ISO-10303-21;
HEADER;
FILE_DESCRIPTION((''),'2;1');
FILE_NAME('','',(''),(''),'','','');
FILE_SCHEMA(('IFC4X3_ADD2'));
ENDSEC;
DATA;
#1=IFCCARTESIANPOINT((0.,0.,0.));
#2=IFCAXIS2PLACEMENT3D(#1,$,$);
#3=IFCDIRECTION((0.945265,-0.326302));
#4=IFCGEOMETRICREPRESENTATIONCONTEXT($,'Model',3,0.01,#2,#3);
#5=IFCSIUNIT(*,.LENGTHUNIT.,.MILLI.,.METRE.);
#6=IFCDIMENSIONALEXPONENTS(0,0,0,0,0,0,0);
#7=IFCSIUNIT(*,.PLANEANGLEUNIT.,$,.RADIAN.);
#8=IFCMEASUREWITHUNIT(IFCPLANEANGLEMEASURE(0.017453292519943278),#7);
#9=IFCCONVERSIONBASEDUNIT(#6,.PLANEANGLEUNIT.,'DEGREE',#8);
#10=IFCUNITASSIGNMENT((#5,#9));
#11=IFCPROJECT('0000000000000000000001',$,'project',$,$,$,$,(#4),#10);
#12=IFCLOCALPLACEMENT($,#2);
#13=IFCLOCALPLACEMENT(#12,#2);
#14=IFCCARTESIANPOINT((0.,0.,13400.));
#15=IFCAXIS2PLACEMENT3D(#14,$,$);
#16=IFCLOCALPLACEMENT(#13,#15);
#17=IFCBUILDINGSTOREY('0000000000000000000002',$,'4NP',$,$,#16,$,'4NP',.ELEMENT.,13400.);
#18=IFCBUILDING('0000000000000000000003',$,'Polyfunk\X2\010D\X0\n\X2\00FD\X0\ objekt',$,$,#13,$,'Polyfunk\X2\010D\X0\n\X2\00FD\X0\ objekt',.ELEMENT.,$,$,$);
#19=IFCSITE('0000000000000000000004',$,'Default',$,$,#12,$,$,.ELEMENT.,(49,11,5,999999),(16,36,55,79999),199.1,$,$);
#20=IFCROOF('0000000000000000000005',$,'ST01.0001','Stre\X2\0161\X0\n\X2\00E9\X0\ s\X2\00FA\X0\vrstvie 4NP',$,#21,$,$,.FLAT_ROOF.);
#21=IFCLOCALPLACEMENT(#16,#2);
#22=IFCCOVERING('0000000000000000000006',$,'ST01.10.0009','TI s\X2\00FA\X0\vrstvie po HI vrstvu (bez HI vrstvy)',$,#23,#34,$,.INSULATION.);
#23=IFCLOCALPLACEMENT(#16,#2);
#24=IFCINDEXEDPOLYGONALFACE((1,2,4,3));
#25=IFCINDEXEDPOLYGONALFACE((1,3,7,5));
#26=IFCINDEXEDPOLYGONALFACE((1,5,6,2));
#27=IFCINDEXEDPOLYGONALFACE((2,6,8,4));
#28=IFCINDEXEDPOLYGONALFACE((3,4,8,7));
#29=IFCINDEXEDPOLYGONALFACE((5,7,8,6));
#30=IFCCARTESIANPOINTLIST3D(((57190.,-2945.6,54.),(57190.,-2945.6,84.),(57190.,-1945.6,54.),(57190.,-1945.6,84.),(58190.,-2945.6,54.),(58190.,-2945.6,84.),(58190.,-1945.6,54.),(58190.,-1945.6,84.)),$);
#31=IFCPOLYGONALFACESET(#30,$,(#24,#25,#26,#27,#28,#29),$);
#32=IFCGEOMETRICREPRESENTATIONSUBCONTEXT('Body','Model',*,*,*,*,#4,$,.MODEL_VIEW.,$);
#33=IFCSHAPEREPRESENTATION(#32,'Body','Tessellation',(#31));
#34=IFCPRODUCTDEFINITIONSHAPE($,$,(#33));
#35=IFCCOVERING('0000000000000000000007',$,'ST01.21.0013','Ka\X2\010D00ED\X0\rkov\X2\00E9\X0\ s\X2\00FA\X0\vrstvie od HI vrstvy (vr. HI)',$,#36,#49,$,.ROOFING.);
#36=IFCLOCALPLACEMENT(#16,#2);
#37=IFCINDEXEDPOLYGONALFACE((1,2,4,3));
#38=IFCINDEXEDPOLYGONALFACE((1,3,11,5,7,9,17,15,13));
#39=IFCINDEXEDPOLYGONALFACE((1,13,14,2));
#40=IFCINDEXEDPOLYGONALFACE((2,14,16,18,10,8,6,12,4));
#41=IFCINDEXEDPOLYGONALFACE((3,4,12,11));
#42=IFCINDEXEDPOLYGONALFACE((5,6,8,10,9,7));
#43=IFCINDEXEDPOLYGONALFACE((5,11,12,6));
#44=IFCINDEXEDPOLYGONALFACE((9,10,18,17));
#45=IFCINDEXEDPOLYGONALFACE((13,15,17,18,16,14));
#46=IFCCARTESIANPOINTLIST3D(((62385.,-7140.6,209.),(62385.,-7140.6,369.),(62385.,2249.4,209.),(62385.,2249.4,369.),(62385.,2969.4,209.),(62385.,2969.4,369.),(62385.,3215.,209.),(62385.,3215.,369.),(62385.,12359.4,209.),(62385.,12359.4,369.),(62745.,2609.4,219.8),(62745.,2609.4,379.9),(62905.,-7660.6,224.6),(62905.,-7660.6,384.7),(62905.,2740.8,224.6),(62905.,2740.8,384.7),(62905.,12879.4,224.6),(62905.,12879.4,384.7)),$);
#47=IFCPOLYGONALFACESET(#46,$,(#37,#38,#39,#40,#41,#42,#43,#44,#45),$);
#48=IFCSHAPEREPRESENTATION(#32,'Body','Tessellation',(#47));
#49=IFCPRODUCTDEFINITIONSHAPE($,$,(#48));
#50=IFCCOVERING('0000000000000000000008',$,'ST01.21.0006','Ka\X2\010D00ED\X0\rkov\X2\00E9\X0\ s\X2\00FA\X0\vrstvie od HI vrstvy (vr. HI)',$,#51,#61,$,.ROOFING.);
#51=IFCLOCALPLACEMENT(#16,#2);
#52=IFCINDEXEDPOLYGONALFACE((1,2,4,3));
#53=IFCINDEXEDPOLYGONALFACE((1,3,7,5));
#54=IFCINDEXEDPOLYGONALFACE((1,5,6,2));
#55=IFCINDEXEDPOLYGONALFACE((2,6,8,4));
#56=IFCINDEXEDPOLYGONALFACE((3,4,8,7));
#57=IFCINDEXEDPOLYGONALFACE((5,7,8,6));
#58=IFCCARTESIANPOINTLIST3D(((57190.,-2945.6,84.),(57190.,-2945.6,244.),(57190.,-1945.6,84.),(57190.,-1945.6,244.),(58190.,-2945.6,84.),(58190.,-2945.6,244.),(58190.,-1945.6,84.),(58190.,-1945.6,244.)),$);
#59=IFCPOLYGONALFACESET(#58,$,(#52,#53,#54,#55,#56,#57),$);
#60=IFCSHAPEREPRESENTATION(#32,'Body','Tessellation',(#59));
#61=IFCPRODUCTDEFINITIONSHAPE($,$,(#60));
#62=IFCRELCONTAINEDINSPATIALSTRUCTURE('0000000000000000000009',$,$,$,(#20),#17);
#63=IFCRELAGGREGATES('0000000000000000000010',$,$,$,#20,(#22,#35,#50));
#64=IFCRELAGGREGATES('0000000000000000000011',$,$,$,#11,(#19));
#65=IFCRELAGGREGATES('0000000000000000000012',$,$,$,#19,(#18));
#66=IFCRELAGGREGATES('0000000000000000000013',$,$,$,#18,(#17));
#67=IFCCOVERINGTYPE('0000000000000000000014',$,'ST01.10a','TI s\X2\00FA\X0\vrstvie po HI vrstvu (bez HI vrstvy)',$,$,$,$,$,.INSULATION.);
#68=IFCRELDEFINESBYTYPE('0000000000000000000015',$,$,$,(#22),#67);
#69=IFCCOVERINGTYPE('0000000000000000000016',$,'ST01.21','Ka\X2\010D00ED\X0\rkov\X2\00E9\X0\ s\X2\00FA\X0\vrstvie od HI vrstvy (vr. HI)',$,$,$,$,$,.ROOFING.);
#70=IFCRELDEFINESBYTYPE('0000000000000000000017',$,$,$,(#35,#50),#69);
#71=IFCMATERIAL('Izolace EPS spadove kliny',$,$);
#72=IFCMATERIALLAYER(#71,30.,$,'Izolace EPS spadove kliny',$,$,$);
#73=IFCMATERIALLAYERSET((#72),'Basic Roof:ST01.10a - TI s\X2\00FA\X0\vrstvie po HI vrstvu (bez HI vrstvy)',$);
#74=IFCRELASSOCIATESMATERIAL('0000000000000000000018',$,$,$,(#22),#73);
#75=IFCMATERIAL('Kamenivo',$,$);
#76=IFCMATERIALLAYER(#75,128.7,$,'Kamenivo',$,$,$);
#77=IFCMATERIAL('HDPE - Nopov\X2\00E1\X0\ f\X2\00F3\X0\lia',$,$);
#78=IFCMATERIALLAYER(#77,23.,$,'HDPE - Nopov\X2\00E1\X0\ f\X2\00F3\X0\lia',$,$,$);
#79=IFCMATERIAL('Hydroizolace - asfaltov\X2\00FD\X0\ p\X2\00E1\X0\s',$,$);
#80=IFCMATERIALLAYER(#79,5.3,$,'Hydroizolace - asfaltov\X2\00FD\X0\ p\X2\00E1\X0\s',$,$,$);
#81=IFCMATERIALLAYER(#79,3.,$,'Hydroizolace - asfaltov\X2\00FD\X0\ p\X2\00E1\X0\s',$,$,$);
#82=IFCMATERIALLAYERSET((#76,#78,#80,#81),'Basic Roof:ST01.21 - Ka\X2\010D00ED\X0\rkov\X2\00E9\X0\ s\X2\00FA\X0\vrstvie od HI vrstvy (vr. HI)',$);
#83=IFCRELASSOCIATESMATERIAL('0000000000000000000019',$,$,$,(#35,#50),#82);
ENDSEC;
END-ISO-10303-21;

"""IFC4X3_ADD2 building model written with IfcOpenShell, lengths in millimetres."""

from ifc_helpers import new_model, entity, si_unit, converted_unit, direction, frame, frame_2d, origin, origin_2d_with_axis, place, context, subcontext, project, spatial, polyline, rectangle, outline, extrude, material, layer, layer_set, type_object, element, aggregate, save


model = new_model("IFC4X3_ADD2")

# Units and contexts
model_context = context("Model", 3, precision=0.01, world=origin(), true_north=direction((0.945265, -0.326302)))
body_context = subcontext(model_context, "Body", "Model", "MODEL_VIEW")
ifc_project = project(units=[si_unit("LENGTHUNIT", "METRE", prefix="MILLI"), converted_unit("PLANEANGLEUNIT", "DEGREE", entity("IfcPlaneAngleMeasure", 0.017453292519943278), si_unit("PLANEANGLEUNIT", "RADIAN"), dimensions=[0, 0, 0, 0, 0, 0, 0])], contexts=[model_context])

# Site, building, storey
site_placement = place(None, origin())
site = spatial("IfcSite", under=ifc_project, at=site_placement, Name="Default", CompositionType="ELEMENT", RefLatitude=(49, 11, 5, 999999), RefLongitude=(16, 36, 55, 79999), RefElevation=199.1)
building_placement = place(site_placement, origin())
building = spatial("IfcBuilding", under=site, at=building_placement, Name="Polyfunkčný objekt", LongName="Polyfunkčný objekt", CompositionType="ELEMENT")
storey_placement = place(building_placement, frame((0.0, 0.0, 13400.0)))
storey = spatial("IfcBuildingStorey", under=building, at=storey_placement, Name="4NP", LongName="4NP", CompositionType="ELEMENT", Elevation=13400.0)

# Roof, coverings
roof = element("IfcRoof", 1, inside=storey, Name="ST01.0001", Description="Strešné súvrstvie 4NP", PredefinedType="FLAT_ROOF")
ifc_material_1 = material(Name="Izolace EPS spadove kliny")
ifc_layer_1 = layer(ifc_material_1, 30.0, Name="Izolace EPS spadove kliny")
ifc_layer_set_1 = layer_set([ifc_layer_1], Name="Basic Roof:ST01.10a - TI súvrstvie po HI vrstvu (bez HI vrstvy)")
covering_type_1 = type_object("IfcCoveringType", Name="ST01.10a", Description="TI súvrstvie po HI vrstvu (bez HI vrstvy)", PredefinedType="INSULATION")
placement_1 = place(storey_placement, frame((57190.0, -2945.6, 54.0)))
covering_1_placement = place(placement_1, origin())
covering_1 = element("IfcCovering", 2, at=covering_1_placement, type_object=covering_type_1, material=ifc_layer_set_1, Name="ST01.10.0009", Description="TI súvrstvie po HI vrstvu (bez HI vrstvy)", PredefinedType="INSULATION", context=body_context, shape_type="SweptSolid", body=[
    extrude(rectangle(XDim=1000.0, YDim=1000.0, at=frame_2d((0.0, 0.0), x_axis=(-1.0, 0.0))), frame((500.0, 500.0, 0.0)), (0.0, 0.0, 1.0), 30.0),
])
ifc_material_2 = material(Name="Kamenivo")
ifc_layer_2 = layer(ifc_material_2, 128.7, Name="Kamenivo")
ifc_material_3 = material(Name="HDPE - Nopová fólia")
ifc_layer_3 = layer(ifc_material_3, 23.0, Name="HDPE - Nopová fólia")
ifc_material_4 = material(Name="Hydroizolace - asfaltový pás")
ifc_layer_4 = layer(ifc_material_4, 5.3, Name="Hydroizolace - asfaltový pás")
ifc_layer_5 = layer(ifc_material_4, 3.0, Name="Hydroizolace - asfaltový pás")
ifc_layer_set_2 = layer_set([ifc_layer_2, ifc_layer_3, ifc_layer_4, ifc_layer_5], Name="Basic Roof:ST01.21 - Kačírkové súvrstvie od HI vrstvy (vr. HI)")
covering_type_2 = type_object("IfcCoveringType", Name="ST01.21", Description="Kačírkové súvrstvie od HI vrstvy (vr. HI)", PredefinedType="ROOFING")
placement_2 = place(storey_placement, frame((62385.0, -7660.6, 209.0)))
covering_2_placement = place(placement_2, origin())
covering_2 = element("IfcCovering", 3, at=covering_2_placement, type_object=covering_type_2, material=ifc_layer_set_2, Name="ST01.21.0013", Description="Kačírkové súvrstvie od HI vrstvy (vr. HI)", PredefinedType="ROOFING", context=body_context, shape_type="SweptSolid", body=[
    extrude(outline(polyline([(-260.1, -9750.0), (260.1, -10270.0), (260.1, 131.4), (260.1, 10270.0), (-260.1, 9750.0), (-260.1, 605.6), (-260.1, 360.0), (100.0, 0.0), (-260.1, -360.0), (-260.1, -9750.0)])), frame((260.0, 10270.0, 7.8), z_axis=(-0.030015, 0.0, 0.999549), x_axis=(0.999549, 0.0, 0.030015)), (0.030015, 0.0, 0.999549), 160.1),
])
covering_3_placement = place(storey_placement, frame((57190.0, -2945.6, 84.0)))
covering_3 = element("IfcCovering", 4, at=covering_3_placement, type_object=covering_type_2, material=ifc_layer_set_2, Name="ST01.21.0006", Description="Kačírkové súvrstvie od HI vrstvy (vr. HI)", PredefinedType="ROOFING", context=body_context, shape_type="SweptSolid", body=[
    extrude(rectangle(XDim=1000.0, YDim=1000.0, at=origin_2d_with_axis()), frame((500.0, 500.0, 0.0), z_axis=(0.0, 0.0, 1.0), x_axis=(0.0, -1.0, 0.0)), (0.0, 0.0, 1.0), 160.0),
])
aggregate(roof, [covering_1, covering_2, covering_3])

save(model, "model.ifc")
